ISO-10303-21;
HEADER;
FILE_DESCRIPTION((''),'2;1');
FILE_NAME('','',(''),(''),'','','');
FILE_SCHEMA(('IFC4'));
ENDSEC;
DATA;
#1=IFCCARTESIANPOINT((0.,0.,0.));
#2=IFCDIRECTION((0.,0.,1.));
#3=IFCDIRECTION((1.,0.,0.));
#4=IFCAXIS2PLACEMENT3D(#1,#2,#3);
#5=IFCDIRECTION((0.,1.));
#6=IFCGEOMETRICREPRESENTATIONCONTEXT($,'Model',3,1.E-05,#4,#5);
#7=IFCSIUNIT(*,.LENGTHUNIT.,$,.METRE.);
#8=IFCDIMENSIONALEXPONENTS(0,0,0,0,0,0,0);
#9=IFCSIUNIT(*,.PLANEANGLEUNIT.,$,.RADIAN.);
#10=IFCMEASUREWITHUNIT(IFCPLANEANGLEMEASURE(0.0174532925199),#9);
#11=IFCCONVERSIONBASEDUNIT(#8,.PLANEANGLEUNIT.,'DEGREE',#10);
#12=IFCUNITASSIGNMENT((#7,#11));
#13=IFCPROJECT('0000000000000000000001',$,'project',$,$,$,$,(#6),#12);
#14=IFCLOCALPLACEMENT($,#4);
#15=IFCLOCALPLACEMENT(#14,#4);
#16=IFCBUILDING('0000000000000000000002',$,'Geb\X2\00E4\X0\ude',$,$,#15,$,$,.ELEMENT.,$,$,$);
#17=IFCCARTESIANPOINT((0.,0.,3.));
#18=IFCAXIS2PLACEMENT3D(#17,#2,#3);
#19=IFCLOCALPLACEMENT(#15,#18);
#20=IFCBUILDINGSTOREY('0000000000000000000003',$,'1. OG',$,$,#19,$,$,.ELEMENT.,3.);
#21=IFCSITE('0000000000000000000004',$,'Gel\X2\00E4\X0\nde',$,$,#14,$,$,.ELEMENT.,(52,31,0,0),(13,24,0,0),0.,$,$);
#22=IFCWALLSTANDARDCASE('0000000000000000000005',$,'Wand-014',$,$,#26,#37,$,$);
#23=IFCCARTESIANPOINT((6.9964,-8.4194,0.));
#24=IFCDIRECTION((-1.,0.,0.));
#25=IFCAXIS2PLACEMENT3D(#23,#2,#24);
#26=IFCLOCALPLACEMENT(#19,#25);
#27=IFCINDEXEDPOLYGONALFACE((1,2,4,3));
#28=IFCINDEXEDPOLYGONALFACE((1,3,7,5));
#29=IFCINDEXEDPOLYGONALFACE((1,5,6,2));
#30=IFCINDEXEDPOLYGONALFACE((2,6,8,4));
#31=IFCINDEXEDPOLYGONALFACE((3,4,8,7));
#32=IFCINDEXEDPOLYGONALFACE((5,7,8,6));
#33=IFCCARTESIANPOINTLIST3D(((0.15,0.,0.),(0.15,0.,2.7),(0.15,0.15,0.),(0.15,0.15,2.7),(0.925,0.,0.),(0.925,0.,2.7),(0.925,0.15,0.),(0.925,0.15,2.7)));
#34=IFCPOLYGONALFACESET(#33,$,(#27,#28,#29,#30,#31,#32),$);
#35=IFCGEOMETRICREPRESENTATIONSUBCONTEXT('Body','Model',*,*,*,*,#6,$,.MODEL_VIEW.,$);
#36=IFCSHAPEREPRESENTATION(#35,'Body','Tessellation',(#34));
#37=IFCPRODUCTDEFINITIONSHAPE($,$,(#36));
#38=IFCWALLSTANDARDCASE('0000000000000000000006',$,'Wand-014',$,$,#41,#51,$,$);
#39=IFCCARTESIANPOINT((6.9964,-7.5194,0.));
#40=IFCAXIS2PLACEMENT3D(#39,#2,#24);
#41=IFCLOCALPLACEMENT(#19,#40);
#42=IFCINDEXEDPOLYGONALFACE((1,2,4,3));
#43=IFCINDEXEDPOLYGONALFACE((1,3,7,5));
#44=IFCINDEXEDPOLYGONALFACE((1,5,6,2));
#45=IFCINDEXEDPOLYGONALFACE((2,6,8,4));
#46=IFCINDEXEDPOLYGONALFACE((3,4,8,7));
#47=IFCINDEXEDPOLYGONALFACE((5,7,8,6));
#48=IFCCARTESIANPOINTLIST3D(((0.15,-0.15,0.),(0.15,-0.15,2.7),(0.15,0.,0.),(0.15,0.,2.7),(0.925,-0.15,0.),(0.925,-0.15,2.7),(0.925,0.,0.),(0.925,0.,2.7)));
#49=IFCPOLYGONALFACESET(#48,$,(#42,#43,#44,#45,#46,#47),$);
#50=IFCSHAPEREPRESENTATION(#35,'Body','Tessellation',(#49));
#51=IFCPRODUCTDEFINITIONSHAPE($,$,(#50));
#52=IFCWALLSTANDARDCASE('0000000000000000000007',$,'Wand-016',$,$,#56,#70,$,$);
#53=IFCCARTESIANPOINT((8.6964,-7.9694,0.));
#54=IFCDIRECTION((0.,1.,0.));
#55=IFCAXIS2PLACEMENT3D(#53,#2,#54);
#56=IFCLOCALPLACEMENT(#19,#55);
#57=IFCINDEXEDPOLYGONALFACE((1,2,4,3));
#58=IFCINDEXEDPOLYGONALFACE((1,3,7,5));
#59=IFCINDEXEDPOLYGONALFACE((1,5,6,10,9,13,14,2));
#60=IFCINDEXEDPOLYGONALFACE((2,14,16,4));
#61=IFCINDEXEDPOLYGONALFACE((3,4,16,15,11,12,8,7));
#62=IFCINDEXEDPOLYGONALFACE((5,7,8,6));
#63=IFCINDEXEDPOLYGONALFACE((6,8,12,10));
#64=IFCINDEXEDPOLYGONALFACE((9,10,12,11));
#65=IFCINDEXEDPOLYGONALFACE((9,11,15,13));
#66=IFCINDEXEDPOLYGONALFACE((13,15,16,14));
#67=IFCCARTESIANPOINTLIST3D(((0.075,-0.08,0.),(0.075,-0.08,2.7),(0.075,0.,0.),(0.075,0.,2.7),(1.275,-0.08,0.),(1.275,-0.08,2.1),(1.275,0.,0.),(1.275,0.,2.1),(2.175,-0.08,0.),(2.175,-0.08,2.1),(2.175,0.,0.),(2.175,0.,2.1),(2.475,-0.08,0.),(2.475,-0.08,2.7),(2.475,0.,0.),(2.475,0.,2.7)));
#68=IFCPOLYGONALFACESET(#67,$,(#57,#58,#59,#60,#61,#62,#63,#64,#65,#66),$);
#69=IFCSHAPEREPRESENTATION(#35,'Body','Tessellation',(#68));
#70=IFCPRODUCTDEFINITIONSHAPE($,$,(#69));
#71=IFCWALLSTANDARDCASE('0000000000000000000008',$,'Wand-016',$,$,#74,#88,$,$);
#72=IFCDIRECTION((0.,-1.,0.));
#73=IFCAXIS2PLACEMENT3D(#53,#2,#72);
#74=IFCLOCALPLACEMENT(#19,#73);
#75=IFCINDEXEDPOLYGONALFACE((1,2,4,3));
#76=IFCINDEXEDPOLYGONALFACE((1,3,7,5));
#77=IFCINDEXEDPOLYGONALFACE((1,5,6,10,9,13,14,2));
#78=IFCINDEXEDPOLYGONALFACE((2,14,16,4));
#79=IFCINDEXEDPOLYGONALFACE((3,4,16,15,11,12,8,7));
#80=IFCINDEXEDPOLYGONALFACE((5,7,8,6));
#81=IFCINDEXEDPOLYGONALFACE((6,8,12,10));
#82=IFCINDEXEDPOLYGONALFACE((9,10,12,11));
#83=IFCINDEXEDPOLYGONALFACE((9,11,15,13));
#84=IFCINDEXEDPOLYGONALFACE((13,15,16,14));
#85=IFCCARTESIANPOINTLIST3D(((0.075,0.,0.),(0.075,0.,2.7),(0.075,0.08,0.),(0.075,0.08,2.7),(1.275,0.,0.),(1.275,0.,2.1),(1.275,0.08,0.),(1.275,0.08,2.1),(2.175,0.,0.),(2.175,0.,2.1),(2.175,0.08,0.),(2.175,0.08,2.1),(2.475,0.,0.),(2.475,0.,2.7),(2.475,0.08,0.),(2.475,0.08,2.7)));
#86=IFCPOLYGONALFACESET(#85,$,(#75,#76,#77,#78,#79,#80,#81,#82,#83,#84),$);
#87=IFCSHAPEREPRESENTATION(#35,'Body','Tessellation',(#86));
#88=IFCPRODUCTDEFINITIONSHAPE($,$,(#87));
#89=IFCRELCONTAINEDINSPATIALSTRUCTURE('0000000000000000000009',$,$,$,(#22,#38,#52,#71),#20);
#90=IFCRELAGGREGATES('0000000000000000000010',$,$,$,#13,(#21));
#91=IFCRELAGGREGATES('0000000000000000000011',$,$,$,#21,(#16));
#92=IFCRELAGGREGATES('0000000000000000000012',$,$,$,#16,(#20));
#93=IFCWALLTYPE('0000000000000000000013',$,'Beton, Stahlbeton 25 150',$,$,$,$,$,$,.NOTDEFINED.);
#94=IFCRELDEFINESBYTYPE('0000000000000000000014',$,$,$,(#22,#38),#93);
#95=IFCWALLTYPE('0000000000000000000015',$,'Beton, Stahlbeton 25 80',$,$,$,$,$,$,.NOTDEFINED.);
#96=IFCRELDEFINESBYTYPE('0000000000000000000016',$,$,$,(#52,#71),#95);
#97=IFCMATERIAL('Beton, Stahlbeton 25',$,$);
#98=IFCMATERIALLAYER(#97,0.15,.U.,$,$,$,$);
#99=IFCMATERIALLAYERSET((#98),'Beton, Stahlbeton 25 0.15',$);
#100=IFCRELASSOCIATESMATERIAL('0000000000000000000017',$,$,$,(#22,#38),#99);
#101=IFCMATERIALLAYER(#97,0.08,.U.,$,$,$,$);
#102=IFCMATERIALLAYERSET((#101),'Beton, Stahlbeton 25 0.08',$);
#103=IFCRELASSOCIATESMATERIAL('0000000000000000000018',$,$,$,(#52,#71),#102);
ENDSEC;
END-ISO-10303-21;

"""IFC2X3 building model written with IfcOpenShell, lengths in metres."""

from ifc_helpers import new_model, entity, si_unit, converted_unit, direction, frame, origin_with_axes, origin_2d_with_axis, place, context, subcontext, project, spatial, polyline, rectangle, outline, extrude, material, layer, layer_set, layer_usage, type_object, element, save


model = new_model("IFC2X3")

# Units and contexts
model_context = context("Model", 3, precision=1e-05, world=origin_with_axes(), true_north=direction((0.0, 1.0)))
body_context = subcontext(model_context, "Body", "Model", "MODEL_VIEW")
ifc_project = project(units=[si_unit("LENGTHUNIT", "METRE"), converted_unit("PLANEANGLEUNIT", "DEGREE", entity("IfcPlaneAngleMeasure", 0.0174532925199), si_unit("PLANEANGLEUNIT", "RADIAN"), dimensions=[0, 0, 0, 0, 0, 0, 0])], contexts=[model_context])

# Site, building, storey
site_placement = place(None, origin_with_axes())
site = spatial("IfcSite", under=ifc_project, at=site_placement, Name="Gelände", CompositionType="ELEMENT", RefLatitude=(52, 31, 0, 0), RefLongitude=(13, 24, 0, 0), RefElevation=0.0)
building_placement = place(site_placement, origin_with_axes())
building = spatial("IfcBuilding", under=site, at=building_placement, Name="Gebäude", CompositionType="ELEMENT")
storey_placement = place(building_placement, frame((0.0, 0.0, 3.0), z_axis=(0.0, 0.0, 1.0), x_axis=(1.0, 0.0, 0.0)))
storey = spatial("IfcBuildingStorey", under=building, at=storey_placement, Name="1. OG", CompositionType="ELEMENT", Elevation=3.0)

# Shared definitions
ifc_material = material(Name="Beton, Stahlbeton 25")
ifc_layer_1 = layer(ifc_material, 0.15, ventilated="UNKNOWN")
ifc_layer_set_1 = layer_set([ifc_layer_1], Name="Beton, Stahlbeton 25 0.15")
wall_type_1 = type_object("IfcWallType", Name="Beton, Stahlbeton 25 150", PredefinedType="NOTDEFINED")

# Walls
ifc_layer_usage_1 = layer_usage(ifc_layer_set_1, "AXIS2", "POSITIVE", 0.0)
wall_1_placement = place(storey_placement, frame((6.9964, -8.4194, 0.0), z_axis=(0.0, 0.0, 1.0), x_axis=(-1.0, 0.0, 0.0)))
element("IfcWallStandardCase", 1, at=wall_1_placement, inside=storey, type_object=wall_type_1, material=ifc_layer_usage_1, Name="Wand-014", context=body_context, shape_type="SweptSolid", body=[
    extrude(outline(polyline([(0.15, 0.0), (0.925, 0.0), (0.925, 0.15), (0.15, 0.15), (0.15, 0.0)])), origin_with_axes(), (0.0, 0.0, 1.0), 2.7),
])
ifc_layer_usage_2 = layer_usage(ifc_layer_set_1, "AXIS2", "NEGATIVE", 0.0)
wall_2_placement = place(storey_placement, frame((6.9964, -7.5194, 0.0), z_axis=(0.0, 0.0, 1.0), x_axis=(-1.0, 0.0, 0.0)))
element("IfcWallStandardCase", 2, at=wall_2_placement, inside=storey, type_object=wall_type_1, material=ifc_layer_usage_2, Name="Wand-014", context=body_context, shape_type="SweptSolid", body=[
    extrude(outline(polyline([(0.15, -0.15), (0.925, -0.15), (0.925, 0.0), (0.15, 0.0), (0.15, -0.15)])), origin_with_axes(), (0.0, 0.0, 1.0), 2.7),
])

# Walls, openings
ifc_layer_2 = layer(ifc_material, 0.08, ventilated="UNKNOWN")
ifc_layer_set_2 = layer_set([ifc_layer_2], Name="Beton, Stahlbeton 25 0.08")
ifc_layer_usage_3 = layer_usage(ifc_layer_set_2, "AXIS2", "NEGATIVE", 0.0)
wall_type_2 = type_object("IfcWallType", Name="Beton, Stahlbeton 25 80", PredefinedType="NOTDEFINED")
wall_3_placement = place(storey_placement, frame((8.6964, -7.9694, 0.0), z_axis=(0.0, 0.0, 1.0), x_axis=(0.0, 1.0, 0.0)))
wall_3 = element("IfcWallStandardCase", 3, at=wall_3_placement, inside=storey, type_object=wall_type_2, material=ifc_layer_usage_3, Name="Wand-016", context=body_context, shape_type="SweptSolid", body=[
    extrude(outline(polyline([(0.075, -0.08), (2.475, -0.08), (2.475, 0.0), (0.075, 0.0), (0.075, -0.08)])), origin_with_axes(), (0.0, 0.0, 1.0), 2.7),
])
opening_1_placement = place(wall_3_placement, frame((1.725, 0.0, 0.0), z_axis=(0.0, 0.0, 1.0), x_axis=(1.0, 0.0, 0.0)))
element("IfcOpeningElement", 4, at=opening_1_placement, cuts=wall_3, context=body_context, shape_type="SweptSolid", body=[
    extrude(rectangle(XDim=0.9, YDim=2.1, at=origin_2d_with_axis()), frame((0.0, -0.16, 1.05), z_axis=(0.0, 1.0, 0.0), x_axis=(1.0, 0.0, 0.0)), (0.0, 0.0, 1.0), 0.08),
    extrude(rectangle(XDim=0.9, YDim=2.1, at=origin_2d_with_axis()), frame((0.0, 0.0, 1.05), z_axis=(0.0, -1.0, 0.0), x_axis=(1.0, 0.0, 0.0)), (0.0, 0.0, 1.0), 0.08),
])
ifc_layer_usage_4 = layer_usage(ifc_layer_set_2, "AXIS2", "POSITIVE", 0.0)
wall_4_placement = place(storey_placement, frame((8.6964, -7.9694, 0.0), z_axis=(0.0, 0.0, 1.0), x_axis=(0.0, -1.0, 0.0)))
wall_4 = element("IfcWallStandardCase", 5, at=wall_4_placement, inside=storey, type_object=wall_type_2, material=ifc_layer_usage_4, Name="Wand-016", context=body_context, shape_type="SweptSolid", body=[
    extrude(outline(polyline([(0.075, 0.0), (2.475, 0.0), (2.475, 0.08), (0.075, 0.08), (0.075, 0.0)])), origin_with_axes(), (0.0, 0.0, 1.0), 2.7),
])
opening_2_placement = place(wall_4_placement, frame((1.725, 0.0, 0.0), z_axis=(0.0, 0.0, 1.0), x_axis=(1.0, 0.0, 0.0)))
element("IfcOpeningElement", 6, at=opening_2_placement, cuts=wall_4, context=body_context, shape_type="SweptSolid", body=[
    extrude(rectangle(XDim=0.9, YDim=2.1, at=origin_2d_with_axis()), frame((0.0, 0.16, 1.05), z_axis=(0.0, -1.0, 0.0), x_axis=(1.0, 0.0, 0.0)), (0.0, 0.0, 1.0), 0.08),
    extrude(rectangle(XDim=0.9, YDim=2.1, at=origin_2d_with_axis()), frame((0.0, 0.0, 1.05), z_axis=(0.0, 1.0, 0.0), x_axis=(1.0, 0.0, 0.0)), (0.0, 0.0, 1.0), 0.08),
])

save(model, "model.ifc")
